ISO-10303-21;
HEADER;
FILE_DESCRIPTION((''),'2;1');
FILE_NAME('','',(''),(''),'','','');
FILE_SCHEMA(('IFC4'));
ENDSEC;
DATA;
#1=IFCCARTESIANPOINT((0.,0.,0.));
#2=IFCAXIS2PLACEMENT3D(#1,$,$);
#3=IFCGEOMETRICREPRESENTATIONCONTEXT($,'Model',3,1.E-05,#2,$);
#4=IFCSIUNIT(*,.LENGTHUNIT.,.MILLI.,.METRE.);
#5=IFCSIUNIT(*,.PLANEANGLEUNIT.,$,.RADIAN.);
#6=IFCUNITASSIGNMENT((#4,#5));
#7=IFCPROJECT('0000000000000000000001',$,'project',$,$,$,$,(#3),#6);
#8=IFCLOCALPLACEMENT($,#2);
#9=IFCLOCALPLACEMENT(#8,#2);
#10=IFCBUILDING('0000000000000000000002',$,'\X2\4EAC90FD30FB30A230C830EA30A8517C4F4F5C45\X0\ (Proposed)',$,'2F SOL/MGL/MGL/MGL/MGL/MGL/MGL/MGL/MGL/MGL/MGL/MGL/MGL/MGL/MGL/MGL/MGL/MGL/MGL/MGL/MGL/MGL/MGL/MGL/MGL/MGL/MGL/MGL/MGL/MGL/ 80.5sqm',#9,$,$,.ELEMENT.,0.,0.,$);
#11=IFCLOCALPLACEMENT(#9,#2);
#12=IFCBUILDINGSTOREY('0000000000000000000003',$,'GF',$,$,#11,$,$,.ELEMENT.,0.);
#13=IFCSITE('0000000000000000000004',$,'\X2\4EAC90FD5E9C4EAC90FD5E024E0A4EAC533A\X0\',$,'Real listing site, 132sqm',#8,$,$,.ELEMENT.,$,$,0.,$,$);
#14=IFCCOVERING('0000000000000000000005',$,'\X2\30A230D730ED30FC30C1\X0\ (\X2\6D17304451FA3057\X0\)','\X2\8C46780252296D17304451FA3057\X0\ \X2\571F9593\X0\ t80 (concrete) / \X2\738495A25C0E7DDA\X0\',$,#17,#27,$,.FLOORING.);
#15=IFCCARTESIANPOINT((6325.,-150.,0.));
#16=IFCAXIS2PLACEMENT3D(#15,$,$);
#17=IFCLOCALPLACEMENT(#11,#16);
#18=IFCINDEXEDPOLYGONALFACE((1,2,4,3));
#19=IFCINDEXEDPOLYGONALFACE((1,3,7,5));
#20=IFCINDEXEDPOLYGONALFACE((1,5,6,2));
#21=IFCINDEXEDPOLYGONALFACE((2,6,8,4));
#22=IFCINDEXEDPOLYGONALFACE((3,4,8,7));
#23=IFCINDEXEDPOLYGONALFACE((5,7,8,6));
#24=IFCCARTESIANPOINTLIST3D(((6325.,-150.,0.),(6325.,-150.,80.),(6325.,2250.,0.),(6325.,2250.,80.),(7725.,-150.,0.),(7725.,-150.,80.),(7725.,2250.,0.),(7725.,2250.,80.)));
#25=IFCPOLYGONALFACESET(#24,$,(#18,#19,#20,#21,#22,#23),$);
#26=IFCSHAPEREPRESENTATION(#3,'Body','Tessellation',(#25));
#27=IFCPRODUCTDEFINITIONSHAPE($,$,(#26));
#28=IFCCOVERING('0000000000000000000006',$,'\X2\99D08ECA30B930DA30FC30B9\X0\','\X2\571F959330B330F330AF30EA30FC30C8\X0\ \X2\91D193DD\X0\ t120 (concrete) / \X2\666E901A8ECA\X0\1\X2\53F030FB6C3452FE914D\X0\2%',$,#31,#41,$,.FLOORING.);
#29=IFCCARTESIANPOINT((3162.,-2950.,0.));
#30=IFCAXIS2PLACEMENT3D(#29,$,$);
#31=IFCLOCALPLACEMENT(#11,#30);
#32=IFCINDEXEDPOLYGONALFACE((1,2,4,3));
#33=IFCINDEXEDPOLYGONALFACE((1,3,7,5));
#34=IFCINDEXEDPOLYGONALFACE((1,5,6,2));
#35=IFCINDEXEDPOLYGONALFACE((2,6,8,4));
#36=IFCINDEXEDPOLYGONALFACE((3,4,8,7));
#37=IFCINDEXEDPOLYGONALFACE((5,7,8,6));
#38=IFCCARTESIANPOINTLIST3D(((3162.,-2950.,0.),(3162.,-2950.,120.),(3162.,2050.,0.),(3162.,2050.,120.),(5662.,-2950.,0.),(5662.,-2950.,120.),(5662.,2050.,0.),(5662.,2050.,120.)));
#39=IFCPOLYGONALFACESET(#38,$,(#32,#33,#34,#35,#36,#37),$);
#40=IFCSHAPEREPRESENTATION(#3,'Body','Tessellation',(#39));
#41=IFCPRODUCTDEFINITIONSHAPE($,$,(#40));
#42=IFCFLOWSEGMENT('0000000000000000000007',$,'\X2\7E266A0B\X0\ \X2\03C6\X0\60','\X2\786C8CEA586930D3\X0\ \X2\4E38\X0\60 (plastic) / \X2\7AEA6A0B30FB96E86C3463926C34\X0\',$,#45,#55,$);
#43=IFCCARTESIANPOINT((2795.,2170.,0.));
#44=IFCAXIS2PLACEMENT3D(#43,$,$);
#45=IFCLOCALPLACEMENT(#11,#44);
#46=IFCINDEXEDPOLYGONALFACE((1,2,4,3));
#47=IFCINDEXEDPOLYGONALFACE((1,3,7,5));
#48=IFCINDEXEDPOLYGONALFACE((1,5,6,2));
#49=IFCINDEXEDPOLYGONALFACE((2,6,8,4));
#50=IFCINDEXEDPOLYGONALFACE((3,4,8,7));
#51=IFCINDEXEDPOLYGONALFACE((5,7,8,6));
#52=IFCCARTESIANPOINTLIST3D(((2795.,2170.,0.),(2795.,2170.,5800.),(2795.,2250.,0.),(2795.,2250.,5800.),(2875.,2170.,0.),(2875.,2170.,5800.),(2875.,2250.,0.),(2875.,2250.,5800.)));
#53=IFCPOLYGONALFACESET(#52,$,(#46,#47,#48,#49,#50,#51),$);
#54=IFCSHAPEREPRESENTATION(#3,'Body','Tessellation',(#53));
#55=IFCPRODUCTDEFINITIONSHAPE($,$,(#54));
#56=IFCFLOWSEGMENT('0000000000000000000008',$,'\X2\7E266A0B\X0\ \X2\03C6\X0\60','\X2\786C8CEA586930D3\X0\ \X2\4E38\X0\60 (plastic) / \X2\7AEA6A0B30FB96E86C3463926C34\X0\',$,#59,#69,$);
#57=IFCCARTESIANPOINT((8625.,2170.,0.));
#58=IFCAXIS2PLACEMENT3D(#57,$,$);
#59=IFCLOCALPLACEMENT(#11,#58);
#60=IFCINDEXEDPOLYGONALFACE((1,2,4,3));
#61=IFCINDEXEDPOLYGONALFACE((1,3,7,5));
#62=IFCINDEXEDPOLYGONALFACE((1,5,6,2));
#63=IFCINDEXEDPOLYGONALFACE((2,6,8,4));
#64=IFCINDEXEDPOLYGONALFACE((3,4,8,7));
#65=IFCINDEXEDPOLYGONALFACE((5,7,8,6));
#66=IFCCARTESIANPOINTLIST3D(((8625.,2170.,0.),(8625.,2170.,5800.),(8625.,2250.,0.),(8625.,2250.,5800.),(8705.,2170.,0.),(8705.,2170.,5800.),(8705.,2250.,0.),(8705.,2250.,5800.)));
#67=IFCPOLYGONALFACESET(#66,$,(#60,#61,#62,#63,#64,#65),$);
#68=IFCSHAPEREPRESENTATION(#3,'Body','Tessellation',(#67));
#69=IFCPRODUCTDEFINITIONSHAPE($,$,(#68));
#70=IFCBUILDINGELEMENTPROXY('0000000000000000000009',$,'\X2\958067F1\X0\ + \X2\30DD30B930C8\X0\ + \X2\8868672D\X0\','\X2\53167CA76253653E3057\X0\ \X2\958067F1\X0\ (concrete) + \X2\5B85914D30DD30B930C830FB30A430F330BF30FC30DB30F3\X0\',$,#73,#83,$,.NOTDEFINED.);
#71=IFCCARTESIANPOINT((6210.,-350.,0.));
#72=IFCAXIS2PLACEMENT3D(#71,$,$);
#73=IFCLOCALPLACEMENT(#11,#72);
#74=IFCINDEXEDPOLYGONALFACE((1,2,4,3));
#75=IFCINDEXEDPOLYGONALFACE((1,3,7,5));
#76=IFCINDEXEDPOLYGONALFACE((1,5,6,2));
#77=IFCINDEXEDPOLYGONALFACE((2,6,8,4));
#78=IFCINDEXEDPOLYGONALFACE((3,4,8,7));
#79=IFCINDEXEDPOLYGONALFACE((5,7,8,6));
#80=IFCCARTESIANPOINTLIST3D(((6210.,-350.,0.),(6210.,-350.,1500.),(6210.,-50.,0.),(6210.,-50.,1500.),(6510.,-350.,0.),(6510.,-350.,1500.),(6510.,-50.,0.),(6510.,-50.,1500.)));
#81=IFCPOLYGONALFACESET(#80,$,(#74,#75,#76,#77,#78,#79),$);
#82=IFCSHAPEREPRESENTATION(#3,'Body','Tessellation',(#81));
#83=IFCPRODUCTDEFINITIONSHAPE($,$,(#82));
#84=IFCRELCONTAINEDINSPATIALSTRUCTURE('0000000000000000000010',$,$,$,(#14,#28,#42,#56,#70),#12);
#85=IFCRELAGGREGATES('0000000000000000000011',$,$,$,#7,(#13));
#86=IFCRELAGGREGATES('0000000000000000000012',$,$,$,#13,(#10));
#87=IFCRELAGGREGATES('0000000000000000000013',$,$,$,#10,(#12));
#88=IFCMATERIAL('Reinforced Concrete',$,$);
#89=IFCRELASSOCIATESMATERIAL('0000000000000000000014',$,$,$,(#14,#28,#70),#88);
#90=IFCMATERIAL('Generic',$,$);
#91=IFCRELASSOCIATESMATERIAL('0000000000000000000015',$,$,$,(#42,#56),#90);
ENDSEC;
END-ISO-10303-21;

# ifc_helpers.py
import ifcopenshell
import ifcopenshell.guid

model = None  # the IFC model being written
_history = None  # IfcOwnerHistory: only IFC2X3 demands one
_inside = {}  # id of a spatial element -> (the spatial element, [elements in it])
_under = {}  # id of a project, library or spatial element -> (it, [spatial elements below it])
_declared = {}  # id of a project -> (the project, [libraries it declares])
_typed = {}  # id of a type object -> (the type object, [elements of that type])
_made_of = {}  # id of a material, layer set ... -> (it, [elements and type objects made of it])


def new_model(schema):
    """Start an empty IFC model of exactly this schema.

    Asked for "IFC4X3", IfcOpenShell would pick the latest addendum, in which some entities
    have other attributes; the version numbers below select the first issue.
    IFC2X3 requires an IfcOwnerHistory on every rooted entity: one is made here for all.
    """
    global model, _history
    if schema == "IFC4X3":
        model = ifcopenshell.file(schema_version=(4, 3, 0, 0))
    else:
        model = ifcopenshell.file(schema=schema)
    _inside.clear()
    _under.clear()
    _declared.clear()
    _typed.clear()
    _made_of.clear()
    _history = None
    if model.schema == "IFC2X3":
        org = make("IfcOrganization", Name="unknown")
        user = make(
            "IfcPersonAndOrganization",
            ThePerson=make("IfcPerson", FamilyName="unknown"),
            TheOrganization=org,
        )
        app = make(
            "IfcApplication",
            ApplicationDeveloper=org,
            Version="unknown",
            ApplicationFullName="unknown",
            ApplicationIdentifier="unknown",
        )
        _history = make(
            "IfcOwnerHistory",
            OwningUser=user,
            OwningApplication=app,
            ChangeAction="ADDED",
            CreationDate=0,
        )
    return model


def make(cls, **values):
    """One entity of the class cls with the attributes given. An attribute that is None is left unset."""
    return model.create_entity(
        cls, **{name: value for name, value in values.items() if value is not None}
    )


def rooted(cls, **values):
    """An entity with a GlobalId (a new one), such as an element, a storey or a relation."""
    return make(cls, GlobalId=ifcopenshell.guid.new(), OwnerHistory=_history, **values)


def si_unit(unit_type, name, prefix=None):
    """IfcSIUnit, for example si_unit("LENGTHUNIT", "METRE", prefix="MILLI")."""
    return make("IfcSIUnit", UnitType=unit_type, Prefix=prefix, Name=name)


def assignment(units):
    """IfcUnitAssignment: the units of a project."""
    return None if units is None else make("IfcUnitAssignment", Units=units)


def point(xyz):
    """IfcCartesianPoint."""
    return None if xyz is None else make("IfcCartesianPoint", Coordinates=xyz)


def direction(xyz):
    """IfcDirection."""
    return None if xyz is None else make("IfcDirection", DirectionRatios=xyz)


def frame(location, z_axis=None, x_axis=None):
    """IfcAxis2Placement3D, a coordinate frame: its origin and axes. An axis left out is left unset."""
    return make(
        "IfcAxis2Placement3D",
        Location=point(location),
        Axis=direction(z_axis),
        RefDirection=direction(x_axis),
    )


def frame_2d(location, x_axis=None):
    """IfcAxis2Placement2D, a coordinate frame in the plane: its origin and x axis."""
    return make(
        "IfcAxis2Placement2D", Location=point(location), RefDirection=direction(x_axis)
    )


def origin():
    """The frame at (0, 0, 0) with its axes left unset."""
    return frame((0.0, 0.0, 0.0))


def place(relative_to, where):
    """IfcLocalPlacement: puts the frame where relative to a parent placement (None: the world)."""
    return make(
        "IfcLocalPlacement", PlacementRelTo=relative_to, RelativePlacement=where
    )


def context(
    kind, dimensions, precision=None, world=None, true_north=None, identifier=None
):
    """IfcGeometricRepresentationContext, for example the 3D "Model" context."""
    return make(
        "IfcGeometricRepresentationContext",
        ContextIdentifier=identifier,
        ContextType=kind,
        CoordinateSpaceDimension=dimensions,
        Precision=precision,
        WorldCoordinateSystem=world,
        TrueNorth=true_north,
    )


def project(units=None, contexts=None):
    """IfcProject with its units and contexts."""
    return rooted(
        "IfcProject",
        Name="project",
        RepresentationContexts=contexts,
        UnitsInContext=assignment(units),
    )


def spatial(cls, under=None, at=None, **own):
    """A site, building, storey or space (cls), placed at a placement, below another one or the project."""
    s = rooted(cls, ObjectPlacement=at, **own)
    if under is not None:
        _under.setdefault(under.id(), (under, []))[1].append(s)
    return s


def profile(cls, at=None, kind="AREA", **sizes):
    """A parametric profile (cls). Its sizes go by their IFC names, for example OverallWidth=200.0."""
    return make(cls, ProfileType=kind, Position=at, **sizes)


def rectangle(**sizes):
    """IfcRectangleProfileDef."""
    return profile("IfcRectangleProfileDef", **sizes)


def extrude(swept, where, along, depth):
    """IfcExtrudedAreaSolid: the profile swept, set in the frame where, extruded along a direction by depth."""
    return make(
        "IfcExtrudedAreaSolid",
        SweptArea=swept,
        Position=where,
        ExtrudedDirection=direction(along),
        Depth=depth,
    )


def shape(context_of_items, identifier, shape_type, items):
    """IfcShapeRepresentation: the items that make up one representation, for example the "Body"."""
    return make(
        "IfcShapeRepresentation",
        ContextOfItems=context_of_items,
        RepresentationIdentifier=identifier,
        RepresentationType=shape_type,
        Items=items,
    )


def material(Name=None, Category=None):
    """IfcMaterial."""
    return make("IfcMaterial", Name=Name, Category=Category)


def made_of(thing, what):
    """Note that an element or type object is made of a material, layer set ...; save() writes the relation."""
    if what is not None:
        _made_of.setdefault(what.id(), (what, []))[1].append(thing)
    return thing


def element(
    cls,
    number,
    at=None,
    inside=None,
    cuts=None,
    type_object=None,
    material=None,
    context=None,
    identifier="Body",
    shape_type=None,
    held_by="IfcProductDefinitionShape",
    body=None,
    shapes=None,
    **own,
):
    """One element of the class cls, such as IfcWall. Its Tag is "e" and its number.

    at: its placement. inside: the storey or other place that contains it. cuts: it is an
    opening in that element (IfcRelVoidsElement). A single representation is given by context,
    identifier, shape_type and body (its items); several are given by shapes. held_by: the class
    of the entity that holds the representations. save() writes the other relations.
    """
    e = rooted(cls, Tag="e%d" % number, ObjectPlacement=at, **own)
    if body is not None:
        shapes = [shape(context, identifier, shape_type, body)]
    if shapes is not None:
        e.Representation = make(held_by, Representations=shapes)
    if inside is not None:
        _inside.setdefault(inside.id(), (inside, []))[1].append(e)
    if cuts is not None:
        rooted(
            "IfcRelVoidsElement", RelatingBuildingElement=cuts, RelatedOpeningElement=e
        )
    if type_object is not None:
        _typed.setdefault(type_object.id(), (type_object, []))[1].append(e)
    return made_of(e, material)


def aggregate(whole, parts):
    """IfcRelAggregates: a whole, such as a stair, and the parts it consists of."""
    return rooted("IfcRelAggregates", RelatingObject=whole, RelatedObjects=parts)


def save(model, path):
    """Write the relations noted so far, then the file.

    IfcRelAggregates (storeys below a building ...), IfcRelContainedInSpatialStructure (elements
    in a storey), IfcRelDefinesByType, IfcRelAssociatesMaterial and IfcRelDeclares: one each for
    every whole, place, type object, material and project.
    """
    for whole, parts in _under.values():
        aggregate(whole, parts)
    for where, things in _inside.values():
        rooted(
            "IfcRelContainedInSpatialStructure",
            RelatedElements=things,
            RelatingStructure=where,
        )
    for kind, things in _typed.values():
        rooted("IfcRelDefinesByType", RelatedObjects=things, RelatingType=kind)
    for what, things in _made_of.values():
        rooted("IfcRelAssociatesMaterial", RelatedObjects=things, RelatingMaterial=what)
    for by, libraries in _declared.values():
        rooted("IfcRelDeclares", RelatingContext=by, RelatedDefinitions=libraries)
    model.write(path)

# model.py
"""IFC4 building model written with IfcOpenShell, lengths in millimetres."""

from ifc_helpers import new_model, si_unit, frame, frame_2d, origin, place, context, project, spatial, rectangle, extrude, material, element, save


model = new_model("IFC4")

# Units and contexts
model_context = context("Model", 3, precision=1e-05, world=origin())
ifc_project = project(units=[si_unit("LENGTHUNIT", "METRE", prefix="MILLI"), si_unit("PLANEANGLEUNIT", "RADIAN")], contexts=[model_context])

# Site, building, storey
site_placement = place(None, origin())
site = spatial("IfcSite", under=ifc_project, at=site_placement, Name="京都府京都市上京区", ObjectType="Real listing site, 132sqm", CompositionType="ELEMENT", RefElevation=0.0)
building_placement = place(site_placement, origin())
building = spatial("IfcBuilding", under=site, at=building_placement, Name="京都・アトリエ兼住居 (Proposed)", ObjectType="2F SOL/MGL/MGL/MGL/MGL/MGL/MGL/MGL/MGL/MGL/MGL/MGL/MGL/MGL/MGL/MGL/MGL/MGL/MGL/MGL/MGL/MGL/MGL/MGL/MGL/MGL/MGL/MGL/MGL/MGL/ 80.5sqm", CompositionType="ELEMENT", ElevationOfRefHeight=0.0, ElevationOfTerrain=0.0)
storey_placement = place(building_placement, origin())
storey = spatial("IfcBuildingStorey", under=building, at=storey_placement, Name="GF", CompositionType="ELEMENT", Elevation=0.0)

# Shared definitions
ifc_material_1 = material(Name="Reinforced Concrete")

# Coverings
covering_1_placement = place(storey_placement, frame((6325.0, -150.0, 0.0)))
element("IfcCovering", 1, at=covering_1_placement, inside=storey, material=ifc_material_1, Name="アプローチ (洗い出し)", Description="豆砂利洗い出し 土間 t80 (concrete) / 玄関導線", PredefinedType="FLOORING", context=model_context, shape_type="SweptSolid", body=[
    extrude(rectangle(XDim=1400.0, YDim=2400.0, at=frame_2d((700.0, 1200.0))), frame((6325.0, -150.0, 0.0)), (0.0, 0.0, 1.0), 80.0),
])
covering_2_placement = place(storey_placement, frame((3162.0, -2950.0, 0.0)))
element("IfcCovering", 2, at=covering_2_placement, inside=storey, material=ifc_material_1, Name="駐車スペース", Description="土間コンクリート 金鏝 t120 (concrete) / 普通車1台・水勾配2%", PredefinedType="FLOORING", context=model_context, shape_type="SweptSolid", body=[
    extrude(rectangle(XDim=2500.0, YDim=5000.0, at=frame_2d((1250.0, 2500.0))), frame((3162.0, -2950.0, 0.0)), (0.0, 0.0, 1.0), 120.0),
])

# Flow segments
ifc_material_2 = material(Name="Generic")
flow_segment_1_placement = place(storey_placement, frame((2795.0, 2170.0, 0.0)))
element("IfcFlowSegment", 3, at=flow_segment_1_placement, inside=storey, material=ifc_material_2, Name="縦樋 φ60", Description="硬質塩ビ 丸60 (plastic) / 竪樋・雨水排水", context=model_context, shape_type="SweptSolid", body=[
    extrude(rectangle(XDim=80.0, YDim=80.0, at=frame_2d((40.0, 40.0))), frame((2795.0, 2170.0, 0.0)), (0.0, 0.0, 1.0), 5800.0),
])
flow_segment_2_placement = place(storey_placement, frame((8625.0, 2170.0, 0.0)))
element("IfcFlowSegment", 4, at=flow_segment_2_placement, inside=storey, material=ifc_material_2, Name="縦樋 φ60", Description="硬質塩ビ 丸60 (plastic) / 竪樋・雨水排水", context=model_context, shape_type="SweptSolid", body=[
    extrude(rectangle(XDim=80.0, YDim=80.0, at=frame_2d((40.0, 40.0))), frame((8625.0, 2170.0, 0.0)), (0.0, 0.0, 1.0), 5800.0),
])

# Building element proxy
proxy_placement = place(storey_placement, frame((6210.0, -350.0, 0.0)))
element("IfcBuildingElementProxy", 5, at=proxy_placement, inside=storey, material=ifc_material_1, Name="門柱 + ポスト + 表札", Description="化粧打放し 門柱 (concrete) + 宅配ポスト・インターホン", PredefinedType="NOTDEFINED", context=model_context, shape_type="SweptSolid", body=[
    extrude(rectangle(XDim=300.0, YDim=300.0, at=frame_2d((150.0, 150.0))), frame((6210.0, -350.0, 0.0)), (0.0, 0.0, 1.0), 1500.0),
])

save(model, "model.ifc")
